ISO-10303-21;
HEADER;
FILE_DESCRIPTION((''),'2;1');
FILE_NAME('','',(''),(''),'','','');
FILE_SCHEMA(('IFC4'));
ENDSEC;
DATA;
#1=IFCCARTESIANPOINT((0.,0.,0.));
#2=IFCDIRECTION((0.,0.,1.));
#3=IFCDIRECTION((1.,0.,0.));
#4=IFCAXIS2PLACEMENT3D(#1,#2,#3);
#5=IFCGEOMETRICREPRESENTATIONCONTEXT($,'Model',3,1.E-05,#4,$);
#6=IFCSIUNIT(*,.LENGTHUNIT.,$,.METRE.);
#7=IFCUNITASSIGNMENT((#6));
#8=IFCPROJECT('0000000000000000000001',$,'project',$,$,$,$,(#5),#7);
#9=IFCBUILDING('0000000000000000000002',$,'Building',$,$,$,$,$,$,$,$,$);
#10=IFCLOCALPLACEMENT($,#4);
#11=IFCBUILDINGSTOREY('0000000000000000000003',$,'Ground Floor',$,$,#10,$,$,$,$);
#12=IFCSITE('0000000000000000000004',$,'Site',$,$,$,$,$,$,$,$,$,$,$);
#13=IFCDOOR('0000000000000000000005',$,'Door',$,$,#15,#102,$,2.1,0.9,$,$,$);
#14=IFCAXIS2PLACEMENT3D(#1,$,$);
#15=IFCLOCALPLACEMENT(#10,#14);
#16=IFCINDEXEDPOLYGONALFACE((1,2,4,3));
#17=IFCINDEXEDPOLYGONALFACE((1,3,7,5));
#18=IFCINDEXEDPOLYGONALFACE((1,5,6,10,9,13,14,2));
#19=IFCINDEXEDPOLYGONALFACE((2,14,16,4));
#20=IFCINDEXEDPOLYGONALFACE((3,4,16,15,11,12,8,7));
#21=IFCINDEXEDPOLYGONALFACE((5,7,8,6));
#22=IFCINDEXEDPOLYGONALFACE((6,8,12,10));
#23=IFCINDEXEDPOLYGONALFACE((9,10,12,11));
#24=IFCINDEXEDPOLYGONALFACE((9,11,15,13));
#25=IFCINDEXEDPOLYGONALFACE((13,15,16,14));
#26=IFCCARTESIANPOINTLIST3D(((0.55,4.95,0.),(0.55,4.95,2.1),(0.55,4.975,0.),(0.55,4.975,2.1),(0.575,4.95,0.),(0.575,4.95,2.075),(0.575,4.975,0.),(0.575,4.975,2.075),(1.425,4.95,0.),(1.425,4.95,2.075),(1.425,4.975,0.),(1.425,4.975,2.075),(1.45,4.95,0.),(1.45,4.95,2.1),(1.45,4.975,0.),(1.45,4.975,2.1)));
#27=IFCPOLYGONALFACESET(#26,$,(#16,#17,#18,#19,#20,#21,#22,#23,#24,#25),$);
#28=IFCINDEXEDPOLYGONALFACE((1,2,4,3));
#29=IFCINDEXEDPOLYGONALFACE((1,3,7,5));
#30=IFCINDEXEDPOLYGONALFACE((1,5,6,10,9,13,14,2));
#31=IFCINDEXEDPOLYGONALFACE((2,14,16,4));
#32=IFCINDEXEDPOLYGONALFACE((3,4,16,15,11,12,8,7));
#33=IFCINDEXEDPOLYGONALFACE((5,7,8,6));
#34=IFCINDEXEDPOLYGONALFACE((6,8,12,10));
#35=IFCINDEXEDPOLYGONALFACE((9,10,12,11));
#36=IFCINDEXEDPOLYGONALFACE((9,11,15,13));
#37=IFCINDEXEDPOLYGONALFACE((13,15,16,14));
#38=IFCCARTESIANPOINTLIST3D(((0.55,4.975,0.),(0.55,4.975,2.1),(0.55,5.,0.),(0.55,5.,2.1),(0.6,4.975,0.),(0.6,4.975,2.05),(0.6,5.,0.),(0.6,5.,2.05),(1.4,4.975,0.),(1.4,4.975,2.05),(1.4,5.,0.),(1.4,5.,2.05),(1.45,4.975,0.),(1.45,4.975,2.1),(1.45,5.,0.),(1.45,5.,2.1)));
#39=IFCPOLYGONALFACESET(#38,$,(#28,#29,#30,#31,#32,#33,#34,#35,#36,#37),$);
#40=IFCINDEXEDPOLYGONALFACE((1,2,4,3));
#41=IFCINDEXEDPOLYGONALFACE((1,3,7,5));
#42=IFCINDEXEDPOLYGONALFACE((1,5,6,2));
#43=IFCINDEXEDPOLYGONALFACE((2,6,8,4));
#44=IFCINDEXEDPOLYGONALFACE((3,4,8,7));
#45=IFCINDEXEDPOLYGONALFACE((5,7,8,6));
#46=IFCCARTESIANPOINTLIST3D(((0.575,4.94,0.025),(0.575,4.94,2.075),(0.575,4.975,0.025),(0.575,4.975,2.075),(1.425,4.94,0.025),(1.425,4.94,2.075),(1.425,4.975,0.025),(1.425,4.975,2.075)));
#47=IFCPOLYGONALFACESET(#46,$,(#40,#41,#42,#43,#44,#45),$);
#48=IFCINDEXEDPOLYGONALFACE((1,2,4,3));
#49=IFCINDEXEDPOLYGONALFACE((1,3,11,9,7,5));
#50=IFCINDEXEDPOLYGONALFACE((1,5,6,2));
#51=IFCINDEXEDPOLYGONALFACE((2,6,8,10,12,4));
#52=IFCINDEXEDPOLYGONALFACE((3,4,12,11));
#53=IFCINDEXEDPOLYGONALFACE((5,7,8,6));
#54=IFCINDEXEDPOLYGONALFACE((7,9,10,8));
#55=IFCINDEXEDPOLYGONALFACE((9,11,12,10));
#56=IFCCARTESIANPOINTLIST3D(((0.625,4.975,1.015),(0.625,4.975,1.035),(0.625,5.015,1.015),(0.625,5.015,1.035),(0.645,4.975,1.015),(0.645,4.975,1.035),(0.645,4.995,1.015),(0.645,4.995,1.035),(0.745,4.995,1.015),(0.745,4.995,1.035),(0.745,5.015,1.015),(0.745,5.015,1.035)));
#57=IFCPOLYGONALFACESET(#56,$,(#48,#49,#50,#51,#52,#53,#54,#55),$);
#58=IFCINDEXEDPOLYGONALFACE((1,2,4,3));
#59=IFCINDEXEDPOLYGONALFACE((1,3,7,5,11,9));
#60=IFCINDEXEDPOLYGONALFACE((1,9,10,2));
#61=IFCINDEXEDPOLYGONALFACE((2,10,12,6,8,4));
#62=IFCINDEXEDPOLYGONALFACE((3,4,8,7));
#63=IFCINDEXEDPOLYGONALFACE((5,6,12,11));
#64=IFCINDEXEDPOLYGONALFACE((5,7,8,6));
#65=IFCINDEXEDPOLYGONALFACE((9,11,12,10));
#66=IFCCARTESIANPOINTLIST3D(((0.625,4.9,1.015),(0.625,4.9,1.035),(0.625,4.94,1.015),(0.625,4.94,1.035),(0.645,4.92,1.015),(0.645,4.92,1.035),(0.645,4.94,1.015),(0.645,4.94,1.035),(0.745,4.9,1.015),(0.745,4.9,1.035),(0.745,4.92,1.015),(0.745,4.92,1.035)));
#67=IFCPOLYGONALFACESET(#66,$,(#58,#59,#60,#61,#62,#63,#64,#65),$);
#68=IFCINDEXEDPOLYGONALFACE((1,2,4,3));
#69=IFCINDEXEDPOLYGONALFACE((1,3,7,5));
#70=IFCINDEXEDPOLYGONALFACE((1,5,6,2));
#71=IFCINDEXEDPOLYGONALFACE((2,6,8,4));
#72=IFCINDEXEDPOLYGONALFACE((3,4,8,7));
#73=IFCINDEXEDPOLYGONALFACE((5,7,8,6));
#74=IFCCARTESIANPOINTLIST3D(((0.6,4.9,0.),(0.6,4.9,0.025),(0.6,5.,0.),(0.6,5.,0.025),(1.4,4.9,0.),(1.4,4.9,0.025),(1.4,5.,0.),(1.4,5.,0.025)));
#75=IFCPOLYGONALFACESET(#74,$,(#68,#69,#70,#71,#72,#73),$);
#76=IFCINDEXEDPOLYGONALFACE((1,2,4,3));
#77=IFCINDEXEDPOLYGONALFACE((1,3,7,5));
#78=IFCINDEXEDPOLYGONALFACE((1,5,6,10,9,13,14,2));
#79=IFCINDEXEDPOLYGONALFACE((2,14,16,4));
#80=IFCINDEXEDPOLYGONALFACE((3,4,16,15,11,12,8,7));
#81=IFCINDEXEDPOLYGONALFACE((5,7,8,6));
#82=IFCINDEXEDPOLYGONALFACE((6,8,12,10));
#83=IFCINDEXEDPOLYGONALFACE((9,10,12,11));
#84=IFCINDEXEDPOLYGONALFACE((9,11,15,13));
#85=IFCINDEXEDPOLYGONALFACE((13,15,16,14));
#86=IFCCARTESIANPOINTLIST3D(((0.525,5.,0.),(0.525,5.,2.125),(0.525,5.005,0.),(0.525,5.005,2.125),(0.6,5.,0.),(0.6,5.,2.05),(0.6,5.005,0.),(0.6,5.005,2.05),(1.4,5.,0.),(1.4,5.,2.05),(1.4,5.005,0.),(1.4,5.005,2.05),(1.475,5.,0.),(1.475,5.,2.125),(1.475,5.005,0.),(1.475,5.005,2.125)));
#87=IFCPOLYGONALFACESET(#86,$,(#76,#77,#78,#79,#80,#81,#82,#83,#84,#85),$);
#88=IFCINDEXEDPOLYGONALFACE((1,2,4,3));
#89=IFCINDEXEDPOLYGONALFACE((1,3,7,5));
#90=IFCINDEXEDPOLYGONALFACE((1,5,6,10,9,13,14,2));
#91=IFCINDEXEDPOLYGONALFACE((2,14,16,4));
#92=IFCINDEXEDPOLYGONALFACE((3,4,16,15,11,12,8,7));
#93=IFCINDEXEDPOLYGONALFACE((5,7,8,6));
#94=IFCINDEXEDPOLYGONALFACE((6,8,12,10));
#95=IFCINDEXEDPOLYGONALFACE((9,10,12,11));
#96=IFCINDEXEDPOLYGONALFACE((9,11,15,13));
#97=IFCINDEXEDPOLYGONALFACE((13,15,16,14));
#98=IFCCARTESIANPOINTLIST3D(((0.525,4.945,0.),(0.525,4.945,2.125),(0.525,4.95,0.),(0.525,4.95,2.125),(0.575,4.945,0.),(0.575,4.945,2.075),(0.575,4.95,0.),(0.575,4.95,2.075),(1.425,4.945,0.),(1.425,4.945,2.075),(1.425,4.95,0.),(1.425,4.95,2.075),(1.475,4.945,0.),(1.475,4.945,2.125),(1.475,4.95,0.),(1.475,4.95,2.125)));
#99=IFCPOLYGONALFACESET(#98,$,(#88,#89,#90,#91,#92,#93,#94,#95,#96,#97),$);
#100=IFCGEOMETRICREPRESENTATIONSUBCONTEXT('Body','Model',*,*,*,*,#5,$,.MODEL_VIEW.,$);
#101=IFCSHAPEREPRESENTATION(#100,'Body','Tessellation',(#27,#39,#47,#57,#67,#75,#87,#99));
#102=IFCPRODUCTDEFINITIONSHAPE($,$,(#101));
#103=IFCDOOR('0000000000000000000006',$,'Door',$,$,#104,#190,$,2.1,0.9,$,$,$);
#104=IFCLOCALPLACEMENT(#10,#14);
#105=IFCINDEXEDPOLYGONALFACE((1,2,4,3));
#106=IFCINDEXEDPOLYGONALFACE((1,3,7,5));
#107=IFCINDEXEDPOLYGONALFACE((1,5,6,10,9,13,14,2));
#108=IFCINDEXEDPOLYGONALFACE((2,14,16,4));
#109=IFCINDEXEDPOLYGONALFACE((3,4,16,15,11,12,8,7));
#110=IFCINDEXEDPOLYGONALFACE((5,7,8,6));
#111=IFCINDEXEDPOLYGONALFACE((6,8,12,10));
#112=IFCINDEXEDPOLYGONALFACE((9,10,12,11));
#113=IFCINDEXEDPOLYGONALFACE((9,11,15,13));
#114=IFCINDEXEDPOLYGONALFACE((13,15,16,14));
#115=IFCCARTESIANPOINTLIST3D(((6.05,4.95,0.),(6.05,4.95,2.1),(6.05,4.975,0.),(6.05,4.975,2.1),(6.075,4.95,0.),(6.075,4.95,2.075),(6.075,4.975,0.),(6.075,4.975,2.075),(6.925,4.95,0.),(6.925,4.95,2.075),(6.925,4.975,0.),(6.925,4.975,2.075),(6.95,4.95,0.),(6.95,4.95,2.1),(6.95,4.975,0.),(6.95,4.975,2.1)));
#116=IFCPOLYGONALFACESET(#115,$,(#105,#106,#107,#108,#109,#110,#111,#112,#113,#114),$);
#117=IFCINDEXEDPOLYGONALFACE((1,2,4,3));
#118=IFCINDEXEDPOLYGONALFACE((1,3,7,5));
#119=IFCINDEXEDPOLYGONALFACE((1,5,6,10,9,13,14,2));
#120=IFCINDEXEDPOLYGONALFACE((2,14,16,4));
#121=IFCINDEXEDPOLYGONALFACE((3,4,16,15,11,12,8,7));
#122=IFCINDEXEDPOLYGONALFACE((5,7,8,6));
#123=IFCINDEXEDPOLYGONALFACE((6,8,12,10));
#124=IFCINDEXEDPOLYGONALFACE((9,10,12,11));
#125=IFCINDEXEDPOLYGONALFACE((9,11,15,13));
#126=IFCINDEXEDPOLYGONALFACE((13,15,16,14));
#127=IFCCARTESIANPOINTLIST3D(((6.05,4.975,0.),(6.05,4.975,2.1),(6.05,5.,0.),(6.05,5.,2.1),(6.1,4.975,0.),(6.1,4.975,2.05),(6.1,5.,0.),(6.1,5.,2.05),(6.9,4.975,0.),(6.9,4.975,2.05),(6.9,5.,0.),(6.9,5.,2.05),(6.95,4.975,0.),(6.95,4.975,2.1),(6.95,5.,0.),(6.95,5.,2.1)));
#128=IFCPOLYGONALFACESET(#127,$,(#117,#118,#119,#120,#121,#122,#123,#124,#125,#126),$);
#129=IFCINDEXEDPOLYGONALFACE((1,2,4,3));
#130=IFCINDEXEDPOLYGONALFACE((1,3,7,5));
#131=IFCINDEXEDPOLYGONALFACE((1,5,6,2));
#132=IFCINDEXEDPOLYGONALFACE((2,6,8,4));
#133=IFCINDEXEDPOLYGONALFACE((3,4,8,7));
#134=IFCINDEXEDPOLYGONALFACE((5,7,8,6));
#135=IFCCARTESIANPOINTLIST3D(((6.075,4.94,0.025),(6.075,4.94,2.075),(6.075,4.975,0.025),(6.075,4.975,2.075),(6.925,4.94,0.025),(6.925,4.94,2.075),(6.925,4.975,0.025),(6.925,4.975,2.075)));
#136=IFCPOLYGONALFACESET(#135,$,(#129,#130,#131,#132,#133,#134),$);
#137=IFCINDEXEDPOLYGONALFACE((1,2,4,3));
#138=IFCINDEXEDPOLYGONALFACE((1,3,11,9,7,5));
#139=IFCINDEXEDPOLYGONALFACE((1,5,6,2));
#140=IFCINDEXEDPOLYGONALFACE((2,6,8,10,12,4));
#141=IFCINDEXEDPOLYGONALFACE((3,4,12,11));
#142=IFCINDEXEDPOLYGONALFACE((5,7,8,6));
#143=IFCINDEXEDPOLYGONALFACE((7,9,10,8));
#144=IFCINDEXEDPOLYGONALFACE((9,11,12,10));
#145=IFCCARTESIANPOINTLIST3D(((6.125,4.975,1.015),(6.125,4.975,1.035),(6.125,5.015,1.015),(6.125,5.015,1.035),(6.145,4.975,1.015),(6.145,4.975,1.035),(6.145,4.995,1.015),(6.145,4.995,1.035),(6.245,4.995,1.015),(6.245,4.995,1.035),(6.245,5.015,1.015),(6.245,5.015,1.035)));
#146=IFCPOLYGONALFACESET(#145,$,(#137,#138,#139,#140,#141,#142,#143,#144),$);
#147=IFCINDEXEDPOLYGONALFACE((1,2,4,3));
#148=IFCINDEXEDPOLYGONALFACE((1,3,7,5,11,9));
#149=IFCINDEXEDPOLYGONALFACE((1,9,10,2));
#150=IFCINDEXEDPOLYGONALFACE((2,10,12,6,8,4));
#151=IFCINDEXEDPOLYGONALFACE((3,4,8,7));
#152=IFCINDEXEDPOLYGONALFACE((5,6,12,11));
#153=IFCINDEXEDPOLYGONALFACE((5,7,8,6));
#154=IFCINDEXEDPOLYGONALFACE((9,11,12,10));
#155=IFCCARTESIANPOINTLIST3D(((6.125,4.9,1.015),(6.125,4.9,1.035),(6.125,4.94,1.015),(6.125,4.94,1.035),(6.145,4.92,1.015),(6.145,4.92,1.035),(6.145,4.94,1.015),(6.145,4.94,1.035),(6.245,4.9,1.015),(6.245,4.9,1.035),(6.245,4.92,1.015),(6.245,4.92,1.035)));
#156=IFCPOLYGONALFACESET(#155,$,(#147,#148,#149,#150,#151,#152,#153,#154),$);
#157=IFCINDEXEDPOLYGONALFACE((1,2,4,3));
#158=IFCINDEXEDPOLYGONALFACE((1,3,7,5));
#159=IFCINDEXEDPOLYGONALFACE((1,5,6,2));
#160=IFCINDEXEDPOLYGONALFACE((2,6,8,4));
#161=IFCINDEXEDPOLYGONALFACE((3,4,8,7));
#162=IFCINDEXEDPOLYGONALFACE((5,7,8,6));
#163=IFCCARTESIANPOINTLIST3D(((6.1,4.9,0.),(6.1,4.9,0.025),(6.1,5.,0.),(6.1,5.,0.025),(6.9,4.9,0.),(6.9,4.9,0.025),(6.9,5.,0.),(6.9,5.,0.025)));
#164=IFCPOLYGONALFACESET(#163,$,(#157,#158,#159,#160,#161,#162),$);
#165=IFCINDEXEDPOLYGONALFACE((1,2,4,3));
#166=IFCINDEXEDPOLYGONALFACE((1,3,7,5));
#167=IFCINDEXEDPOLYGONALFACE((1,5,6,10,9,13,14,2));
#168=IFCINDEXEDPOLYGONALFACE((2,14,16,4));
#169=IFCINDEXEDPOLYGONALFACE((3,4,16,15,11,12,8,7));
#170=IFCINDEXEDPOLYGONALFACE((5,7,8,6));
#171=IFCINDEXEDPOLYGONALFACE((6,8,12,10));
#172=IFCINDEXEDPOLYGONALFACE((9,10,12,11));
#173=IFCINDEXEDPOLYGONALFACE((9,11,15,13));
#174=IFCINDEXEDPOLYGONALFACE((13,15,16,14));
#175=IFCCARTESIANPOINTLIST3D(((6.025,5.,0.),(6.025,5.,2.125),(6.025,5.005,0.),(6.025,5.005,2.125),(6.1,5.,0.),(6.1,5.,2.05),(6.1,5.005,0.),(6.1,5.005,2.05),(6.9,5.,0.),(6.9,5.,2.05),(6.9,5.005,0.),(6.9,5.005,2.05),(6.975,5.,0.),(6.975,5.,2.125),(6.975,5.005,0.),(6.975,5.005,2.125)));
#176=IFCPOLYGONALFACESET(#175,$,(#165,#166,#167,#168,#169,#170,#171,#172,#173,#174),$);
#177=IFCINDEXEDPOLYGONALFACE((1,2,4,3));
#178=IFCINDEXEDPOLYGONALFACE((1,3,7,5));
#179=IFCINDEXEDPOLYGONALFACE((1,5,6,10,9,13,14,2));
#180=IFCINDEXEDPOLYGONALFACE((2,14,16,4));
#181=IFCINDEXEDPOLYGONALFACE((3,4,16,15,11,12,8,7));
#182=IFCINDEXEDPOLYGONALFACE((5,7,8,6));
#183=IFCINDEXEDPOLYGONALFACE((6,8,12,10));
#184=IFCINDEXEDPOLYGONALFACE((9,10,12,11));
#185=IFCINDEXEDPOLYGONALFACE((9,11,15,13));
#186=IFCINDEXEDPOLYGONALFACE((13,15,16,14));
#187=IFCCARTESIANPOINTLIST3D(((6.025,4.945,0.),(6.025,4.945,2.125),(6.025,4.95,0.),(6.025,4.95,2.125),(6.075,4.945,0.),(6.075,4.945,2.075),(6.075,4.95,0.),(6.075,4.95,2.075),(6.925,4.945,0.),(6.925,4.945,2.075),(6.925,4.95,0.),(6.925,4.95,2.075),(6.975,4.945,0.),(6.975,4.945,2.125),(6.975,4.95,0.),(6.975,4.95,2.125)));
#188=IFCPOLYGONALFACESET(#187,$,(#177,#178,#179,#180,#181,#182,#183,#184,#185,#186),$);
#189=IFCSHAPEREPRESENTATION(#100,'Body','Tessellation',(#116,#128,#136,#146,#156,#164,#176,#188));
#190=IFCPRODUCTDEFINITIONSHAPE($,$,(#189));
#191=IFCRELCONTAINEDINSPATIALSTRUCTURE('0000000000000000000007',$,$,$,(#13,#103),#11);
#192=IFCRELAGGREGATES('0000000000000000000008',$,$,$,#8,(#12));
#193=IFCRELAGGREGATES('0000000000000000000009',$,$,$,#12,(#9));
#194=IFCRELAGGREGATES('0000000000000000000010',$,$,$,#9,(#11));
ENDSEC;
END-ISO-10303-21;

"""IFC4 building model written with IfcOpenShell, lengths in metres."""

from ifc_helpers import new_model, si_unit, frame, origin_with_axes, place, context, subcontext, project, spatial, line, indexed_curve, outline, extrude, element, save


model = new_model("IFC4")

# Units and contexts
model_context = context("Model", 3, precision=1e-05, world=origin_with_axes())
body_context = subcontext(model_context, "Body", "Model", "MODEL_VIEW")
ifc_project = project(units=[si_unit("LENGTHUNIT", "METRE")], contexts=[model_context])

# Site, building, storey
site = spatial("IfcSite", under=ifc_project, Name="Site")
building = spatial("IfcBuilding", under=site, Name="Building")
storey_placement = place(None, origin_with_axes())
storey = spatial("IfcBuildingStorey", under=building, at=storey_placement, Name="Ground Floor")

# Doors
door_1_placement = place(storey_placement, frame((1.45, 5.0, 0.0), z_axis=(0.0, 0.0, 1.0), x_axis=(-1.0, 0.0, 0.0)))
element("IfcDoor", 1, at=door_1_placement, inside=storey, Name="Door", OverallHeight=2.1, OverallWidth=0.9, context=body_context, shape_type="SweptSolid", body=[
    extrude(outline(indexed_curve([(0.0, 0.0), (0.0, 2.1), (0.9, 2.1), (0.9, 0.0), (0.875, 0.0), (0.875, 2.075), (0.025, 2.075), (0.025, 0.0)], segments=[line(1, 2, 3, 4, 5, 6, 7, 8, 1)])), frame((0.0, 0.025, 0.0), z_axis=(0.0, -1.0, 0.0), x_axis=(1.0, 0.0, 0.0)), (0.0, 0.0, -1.0), 0.025),
    extrude(outline(indexed_curve([(0.0, 0.0), (0.0, 2.1), (0.9, 2.1), (0.9, 0.0), (0.85, 0.0), (0.85, 2.05), (0.05, 2.05), (0.05, 0.0)], segments=[line(1, 2, 3, 4, 5, 6, 7, 8, 1)])), frame((0.0, 0.0, 0.0), z_axis=(0.0, -1.0, 0.0), x_axis=(1.0, 0.0, 0.0)), (0.0, 0.0, -1.0), 0.025),
    extrude(outline(indexed_curve([(0.0, 0.0), (0.85, 0.0), (0.85, 0.035), (0.0, 0.035)], segments=[line(1, 2, 3, 4, 1)])), frame((0.025, 0.025, 0.025), z_axis=(0.0, 0.0, 1.0), x_axis=(1.0, 0.0, 0.0)), (0.0, 0.0, 1.0), 2.05),
    extrude(outline(indexed_curve([(0.0, 0.0), (0.0, -0.04), (-0.12, -0.04), (-0.12, -0.02), (-0.02, -0.02), (-0.02, 0.0)], segments=[line(1, 2, 3, 4, 5, 6, 1)])), frame((0.825, 0.025, 1.015), z_axis=(0.0, 0.0, 1.0), x_axis=(1.0, 0.0, 0.0)), (0.0, 0.0, 1.0), 0.02),
    extrude(outline(indexed_curve([(0.0, 0.0), (0.0, 0.04), (-0.12, 0.04), (-0.12, 0.02), (-0.02, 0.02), (-0.02, 0.0)], segments=[line(1, 2, 3, 4, 5, 6, 1)])), frame((0.825, 0.06, 1.015), z_axis=(0.0, 0.0, 1.0), x_axis=(1.0, 0.0, 0.0)), (0.0, 0.0, 1.0), 0.02),
    extrude(outline(indexed_curve([(0.0, 0.0), (0.8, 0.0), (0.8, 0.1), (0.0, 0.1)], segments=[line(1, 2, 3, 4, 1)])), frame((0.05, 0.0, 0.0), z_axis=(0.0, 0.0, 1.0), x_axis=(1.0, 0.0, 0.0)), (0.0, 0.0, 1.0), 0.025),
    extrude(outline(indexed_curve([(0.0, 0.0), (0.0, 2.125), (0.95, 2.125), (0.95, 0.0), (0.875, 0.0), (0.875, 2.05), (0.075, 2.05), (0.075, 0.0)], segments=[line(1, 2, 3, 4, 5, 6, 7, 8, 1)])), frame((-0.025, -0.005, 0.0), z_axis=(0.0, -1.0, 0.0), x_axis=(1.0, 0.0, 0.0)), (0.0, 0.0, -1.0), 0.005),
    extrude(outline(indexed_curve([(0.0, 0.0), (0.0, 2.125), (0.95, 2.125), (0.95, 0.0), (0.9, 0.0), (0.9, 2.075), (0.05, 2.075), (0.05, 0.0)], segments=[line(1, 2, 3, 4, 5, 6, 7, 8, 1)])), frame((-0.025, 0.05, 0.0), z_axis=(0.0, -1.0, 0.0), x_axis=(1.0, 0.0, 0.0)), (0.0, 0.0, -1.0), 0.005),
])
door_2_placement = place(storey_placement, frame((6.95, 5.0, 0.0), z_axis=(0.0, 0.0, 1.0), x_axis=(-1.0, 0.0, 0.0)))
element("IfcDoor", 2, at=door_2_placement, inside=storey, Name="Door", OverallHeight=2.1, OverallWidth=0.9, context=body_context, shape_type="SweptSolid", body=[
    extrude(outline(indexed_curve([(0.0, 0.0), (0.0, 2.1), (0.9, 2.1), (0.9, 0.0), (0.875, 0.0), (0.875, 2.075), (0.025, 2.075), (0.025, 0.0)], segments=[line(1, 2, 3, 4, 5, 6, 7, 8, 1)])), frame((0.0, 0.025, 0.0), z_axis=(0.0, -1.0, 0.0), x_axis=(1.0, 0.0, 0.0)), (0.0, 0.0, -1.0), 0.025),
    extrude(outline(indexed_curve([(0.0, 0.0), (0.0, 2.1), (0.9, 2.1), (0.9, 0.0), (0.85, 0.0), (0.85, 2.05), (0.05, 2.05), (0.05, 0.0)], segments=[line(1, 2, 3, 4, 5, 6, 7, 8, 1)])), frame((0.0, 0.0, 0.0), z_axis=(0.0, -1.0, 0.0), x_axis=(1.0, 0.0, 0.0)), (0.0, 0.0, -1.0), 0.025),
    extrude(outline(indexed_curve([(0.0, 0.0), (0.85, 0.0), (0.85, 0.035), (0.0, 0.035)], segments=[line(1, 2, 3, 4, 1)])), frame((0.025, 0.025, 0.025), z_axis=(0.0, 0.0, 1.0), x_axis=(1.0, 0.0, 0.0)), (0.0, 0.0, 1.0), 2.05),
    extrude(outline(indexed_curve([(0.0, 0.0), (0.0, -0.04), (-0.12, -0.04), (-0.12, -0.02), (-0.02, -0.02), (-0.02, 0.0)], segments=[line(1, 2, 3, 4, 5, 6, 1)])), frame((0.825, 0.025, 1.015), z_axis=(0.0, 0.0, 1.0), x_axis=(1.0, 0.0, 0.0)), (0.0, 0.0, 1.0), 0.02),
    extrude(outline(indexed_curve([(0.0, 0.0), (0.0, 0.04), (-0.12, 0.04), (-0.12, 0.02), (-0.02, 0.02), (-0.02, 0.0)], segments=[line(1, 2, 3, 4, 5, 6, 1)])), frame((0.825, 0.06, 1.015), z_axis=(0.0, 0.0, 1.0), x_axis=(1.0, 0.0, 0.0)), (0.0, 0.0, 1.0), 0.02),
    extrude(outline(indexed_curve([(0.0, 0.0), (0.8, 0.0), (0.8, 0.1), (0.0, 0.1)], segments=[line(1, 2, 3, 4, 1)])), frame((0.05, 0.0, 0.0), z_axis=(0.0, 0.0, 1.0), x_axis=(1.0, 0.0, 0.0)), (0.0, 0.0, 1.0), 0.025),
    extrude(outline(indexed_curve([(0.0, 0.0), (0.0, 2.125), (0.95, 2.125), (0.95, 0.0), (0.875, 0.0), (0.875, 2.05), (0.075, 2.05), (0.075, 0.0)], segments=[line(1, 2, 3, 4, 5, 6, 7, 8, 1)])), frame((-0.025, -0.005, 0.0), z_axis=(0.0, -1.0, 0.0), x_axis=(1.0, 0.0, 0.0)), (0.0, 0.0, -1.0), 0.005),
    extrude(outline(indexed_curve([(0.0, 0.0), (0.0, 2.125), (0.95, 2.125), (0.95, 0.0), (0.9, 0.0), (0.9, 2.075), (0.05, 2.075), (0.05, 0.0)], segments=[line(1, 2, 3, 4, 5, 6, 7, 8, 1)])), frame((-0.025, 0.05, 0.0), z_axis=(0.0, -1.0, 0.0), x_axis=(1.0, 0.0, 0.0)), (0.0, 0.0, -1.0), 0.005),
])

save(model, "model.ifc")
